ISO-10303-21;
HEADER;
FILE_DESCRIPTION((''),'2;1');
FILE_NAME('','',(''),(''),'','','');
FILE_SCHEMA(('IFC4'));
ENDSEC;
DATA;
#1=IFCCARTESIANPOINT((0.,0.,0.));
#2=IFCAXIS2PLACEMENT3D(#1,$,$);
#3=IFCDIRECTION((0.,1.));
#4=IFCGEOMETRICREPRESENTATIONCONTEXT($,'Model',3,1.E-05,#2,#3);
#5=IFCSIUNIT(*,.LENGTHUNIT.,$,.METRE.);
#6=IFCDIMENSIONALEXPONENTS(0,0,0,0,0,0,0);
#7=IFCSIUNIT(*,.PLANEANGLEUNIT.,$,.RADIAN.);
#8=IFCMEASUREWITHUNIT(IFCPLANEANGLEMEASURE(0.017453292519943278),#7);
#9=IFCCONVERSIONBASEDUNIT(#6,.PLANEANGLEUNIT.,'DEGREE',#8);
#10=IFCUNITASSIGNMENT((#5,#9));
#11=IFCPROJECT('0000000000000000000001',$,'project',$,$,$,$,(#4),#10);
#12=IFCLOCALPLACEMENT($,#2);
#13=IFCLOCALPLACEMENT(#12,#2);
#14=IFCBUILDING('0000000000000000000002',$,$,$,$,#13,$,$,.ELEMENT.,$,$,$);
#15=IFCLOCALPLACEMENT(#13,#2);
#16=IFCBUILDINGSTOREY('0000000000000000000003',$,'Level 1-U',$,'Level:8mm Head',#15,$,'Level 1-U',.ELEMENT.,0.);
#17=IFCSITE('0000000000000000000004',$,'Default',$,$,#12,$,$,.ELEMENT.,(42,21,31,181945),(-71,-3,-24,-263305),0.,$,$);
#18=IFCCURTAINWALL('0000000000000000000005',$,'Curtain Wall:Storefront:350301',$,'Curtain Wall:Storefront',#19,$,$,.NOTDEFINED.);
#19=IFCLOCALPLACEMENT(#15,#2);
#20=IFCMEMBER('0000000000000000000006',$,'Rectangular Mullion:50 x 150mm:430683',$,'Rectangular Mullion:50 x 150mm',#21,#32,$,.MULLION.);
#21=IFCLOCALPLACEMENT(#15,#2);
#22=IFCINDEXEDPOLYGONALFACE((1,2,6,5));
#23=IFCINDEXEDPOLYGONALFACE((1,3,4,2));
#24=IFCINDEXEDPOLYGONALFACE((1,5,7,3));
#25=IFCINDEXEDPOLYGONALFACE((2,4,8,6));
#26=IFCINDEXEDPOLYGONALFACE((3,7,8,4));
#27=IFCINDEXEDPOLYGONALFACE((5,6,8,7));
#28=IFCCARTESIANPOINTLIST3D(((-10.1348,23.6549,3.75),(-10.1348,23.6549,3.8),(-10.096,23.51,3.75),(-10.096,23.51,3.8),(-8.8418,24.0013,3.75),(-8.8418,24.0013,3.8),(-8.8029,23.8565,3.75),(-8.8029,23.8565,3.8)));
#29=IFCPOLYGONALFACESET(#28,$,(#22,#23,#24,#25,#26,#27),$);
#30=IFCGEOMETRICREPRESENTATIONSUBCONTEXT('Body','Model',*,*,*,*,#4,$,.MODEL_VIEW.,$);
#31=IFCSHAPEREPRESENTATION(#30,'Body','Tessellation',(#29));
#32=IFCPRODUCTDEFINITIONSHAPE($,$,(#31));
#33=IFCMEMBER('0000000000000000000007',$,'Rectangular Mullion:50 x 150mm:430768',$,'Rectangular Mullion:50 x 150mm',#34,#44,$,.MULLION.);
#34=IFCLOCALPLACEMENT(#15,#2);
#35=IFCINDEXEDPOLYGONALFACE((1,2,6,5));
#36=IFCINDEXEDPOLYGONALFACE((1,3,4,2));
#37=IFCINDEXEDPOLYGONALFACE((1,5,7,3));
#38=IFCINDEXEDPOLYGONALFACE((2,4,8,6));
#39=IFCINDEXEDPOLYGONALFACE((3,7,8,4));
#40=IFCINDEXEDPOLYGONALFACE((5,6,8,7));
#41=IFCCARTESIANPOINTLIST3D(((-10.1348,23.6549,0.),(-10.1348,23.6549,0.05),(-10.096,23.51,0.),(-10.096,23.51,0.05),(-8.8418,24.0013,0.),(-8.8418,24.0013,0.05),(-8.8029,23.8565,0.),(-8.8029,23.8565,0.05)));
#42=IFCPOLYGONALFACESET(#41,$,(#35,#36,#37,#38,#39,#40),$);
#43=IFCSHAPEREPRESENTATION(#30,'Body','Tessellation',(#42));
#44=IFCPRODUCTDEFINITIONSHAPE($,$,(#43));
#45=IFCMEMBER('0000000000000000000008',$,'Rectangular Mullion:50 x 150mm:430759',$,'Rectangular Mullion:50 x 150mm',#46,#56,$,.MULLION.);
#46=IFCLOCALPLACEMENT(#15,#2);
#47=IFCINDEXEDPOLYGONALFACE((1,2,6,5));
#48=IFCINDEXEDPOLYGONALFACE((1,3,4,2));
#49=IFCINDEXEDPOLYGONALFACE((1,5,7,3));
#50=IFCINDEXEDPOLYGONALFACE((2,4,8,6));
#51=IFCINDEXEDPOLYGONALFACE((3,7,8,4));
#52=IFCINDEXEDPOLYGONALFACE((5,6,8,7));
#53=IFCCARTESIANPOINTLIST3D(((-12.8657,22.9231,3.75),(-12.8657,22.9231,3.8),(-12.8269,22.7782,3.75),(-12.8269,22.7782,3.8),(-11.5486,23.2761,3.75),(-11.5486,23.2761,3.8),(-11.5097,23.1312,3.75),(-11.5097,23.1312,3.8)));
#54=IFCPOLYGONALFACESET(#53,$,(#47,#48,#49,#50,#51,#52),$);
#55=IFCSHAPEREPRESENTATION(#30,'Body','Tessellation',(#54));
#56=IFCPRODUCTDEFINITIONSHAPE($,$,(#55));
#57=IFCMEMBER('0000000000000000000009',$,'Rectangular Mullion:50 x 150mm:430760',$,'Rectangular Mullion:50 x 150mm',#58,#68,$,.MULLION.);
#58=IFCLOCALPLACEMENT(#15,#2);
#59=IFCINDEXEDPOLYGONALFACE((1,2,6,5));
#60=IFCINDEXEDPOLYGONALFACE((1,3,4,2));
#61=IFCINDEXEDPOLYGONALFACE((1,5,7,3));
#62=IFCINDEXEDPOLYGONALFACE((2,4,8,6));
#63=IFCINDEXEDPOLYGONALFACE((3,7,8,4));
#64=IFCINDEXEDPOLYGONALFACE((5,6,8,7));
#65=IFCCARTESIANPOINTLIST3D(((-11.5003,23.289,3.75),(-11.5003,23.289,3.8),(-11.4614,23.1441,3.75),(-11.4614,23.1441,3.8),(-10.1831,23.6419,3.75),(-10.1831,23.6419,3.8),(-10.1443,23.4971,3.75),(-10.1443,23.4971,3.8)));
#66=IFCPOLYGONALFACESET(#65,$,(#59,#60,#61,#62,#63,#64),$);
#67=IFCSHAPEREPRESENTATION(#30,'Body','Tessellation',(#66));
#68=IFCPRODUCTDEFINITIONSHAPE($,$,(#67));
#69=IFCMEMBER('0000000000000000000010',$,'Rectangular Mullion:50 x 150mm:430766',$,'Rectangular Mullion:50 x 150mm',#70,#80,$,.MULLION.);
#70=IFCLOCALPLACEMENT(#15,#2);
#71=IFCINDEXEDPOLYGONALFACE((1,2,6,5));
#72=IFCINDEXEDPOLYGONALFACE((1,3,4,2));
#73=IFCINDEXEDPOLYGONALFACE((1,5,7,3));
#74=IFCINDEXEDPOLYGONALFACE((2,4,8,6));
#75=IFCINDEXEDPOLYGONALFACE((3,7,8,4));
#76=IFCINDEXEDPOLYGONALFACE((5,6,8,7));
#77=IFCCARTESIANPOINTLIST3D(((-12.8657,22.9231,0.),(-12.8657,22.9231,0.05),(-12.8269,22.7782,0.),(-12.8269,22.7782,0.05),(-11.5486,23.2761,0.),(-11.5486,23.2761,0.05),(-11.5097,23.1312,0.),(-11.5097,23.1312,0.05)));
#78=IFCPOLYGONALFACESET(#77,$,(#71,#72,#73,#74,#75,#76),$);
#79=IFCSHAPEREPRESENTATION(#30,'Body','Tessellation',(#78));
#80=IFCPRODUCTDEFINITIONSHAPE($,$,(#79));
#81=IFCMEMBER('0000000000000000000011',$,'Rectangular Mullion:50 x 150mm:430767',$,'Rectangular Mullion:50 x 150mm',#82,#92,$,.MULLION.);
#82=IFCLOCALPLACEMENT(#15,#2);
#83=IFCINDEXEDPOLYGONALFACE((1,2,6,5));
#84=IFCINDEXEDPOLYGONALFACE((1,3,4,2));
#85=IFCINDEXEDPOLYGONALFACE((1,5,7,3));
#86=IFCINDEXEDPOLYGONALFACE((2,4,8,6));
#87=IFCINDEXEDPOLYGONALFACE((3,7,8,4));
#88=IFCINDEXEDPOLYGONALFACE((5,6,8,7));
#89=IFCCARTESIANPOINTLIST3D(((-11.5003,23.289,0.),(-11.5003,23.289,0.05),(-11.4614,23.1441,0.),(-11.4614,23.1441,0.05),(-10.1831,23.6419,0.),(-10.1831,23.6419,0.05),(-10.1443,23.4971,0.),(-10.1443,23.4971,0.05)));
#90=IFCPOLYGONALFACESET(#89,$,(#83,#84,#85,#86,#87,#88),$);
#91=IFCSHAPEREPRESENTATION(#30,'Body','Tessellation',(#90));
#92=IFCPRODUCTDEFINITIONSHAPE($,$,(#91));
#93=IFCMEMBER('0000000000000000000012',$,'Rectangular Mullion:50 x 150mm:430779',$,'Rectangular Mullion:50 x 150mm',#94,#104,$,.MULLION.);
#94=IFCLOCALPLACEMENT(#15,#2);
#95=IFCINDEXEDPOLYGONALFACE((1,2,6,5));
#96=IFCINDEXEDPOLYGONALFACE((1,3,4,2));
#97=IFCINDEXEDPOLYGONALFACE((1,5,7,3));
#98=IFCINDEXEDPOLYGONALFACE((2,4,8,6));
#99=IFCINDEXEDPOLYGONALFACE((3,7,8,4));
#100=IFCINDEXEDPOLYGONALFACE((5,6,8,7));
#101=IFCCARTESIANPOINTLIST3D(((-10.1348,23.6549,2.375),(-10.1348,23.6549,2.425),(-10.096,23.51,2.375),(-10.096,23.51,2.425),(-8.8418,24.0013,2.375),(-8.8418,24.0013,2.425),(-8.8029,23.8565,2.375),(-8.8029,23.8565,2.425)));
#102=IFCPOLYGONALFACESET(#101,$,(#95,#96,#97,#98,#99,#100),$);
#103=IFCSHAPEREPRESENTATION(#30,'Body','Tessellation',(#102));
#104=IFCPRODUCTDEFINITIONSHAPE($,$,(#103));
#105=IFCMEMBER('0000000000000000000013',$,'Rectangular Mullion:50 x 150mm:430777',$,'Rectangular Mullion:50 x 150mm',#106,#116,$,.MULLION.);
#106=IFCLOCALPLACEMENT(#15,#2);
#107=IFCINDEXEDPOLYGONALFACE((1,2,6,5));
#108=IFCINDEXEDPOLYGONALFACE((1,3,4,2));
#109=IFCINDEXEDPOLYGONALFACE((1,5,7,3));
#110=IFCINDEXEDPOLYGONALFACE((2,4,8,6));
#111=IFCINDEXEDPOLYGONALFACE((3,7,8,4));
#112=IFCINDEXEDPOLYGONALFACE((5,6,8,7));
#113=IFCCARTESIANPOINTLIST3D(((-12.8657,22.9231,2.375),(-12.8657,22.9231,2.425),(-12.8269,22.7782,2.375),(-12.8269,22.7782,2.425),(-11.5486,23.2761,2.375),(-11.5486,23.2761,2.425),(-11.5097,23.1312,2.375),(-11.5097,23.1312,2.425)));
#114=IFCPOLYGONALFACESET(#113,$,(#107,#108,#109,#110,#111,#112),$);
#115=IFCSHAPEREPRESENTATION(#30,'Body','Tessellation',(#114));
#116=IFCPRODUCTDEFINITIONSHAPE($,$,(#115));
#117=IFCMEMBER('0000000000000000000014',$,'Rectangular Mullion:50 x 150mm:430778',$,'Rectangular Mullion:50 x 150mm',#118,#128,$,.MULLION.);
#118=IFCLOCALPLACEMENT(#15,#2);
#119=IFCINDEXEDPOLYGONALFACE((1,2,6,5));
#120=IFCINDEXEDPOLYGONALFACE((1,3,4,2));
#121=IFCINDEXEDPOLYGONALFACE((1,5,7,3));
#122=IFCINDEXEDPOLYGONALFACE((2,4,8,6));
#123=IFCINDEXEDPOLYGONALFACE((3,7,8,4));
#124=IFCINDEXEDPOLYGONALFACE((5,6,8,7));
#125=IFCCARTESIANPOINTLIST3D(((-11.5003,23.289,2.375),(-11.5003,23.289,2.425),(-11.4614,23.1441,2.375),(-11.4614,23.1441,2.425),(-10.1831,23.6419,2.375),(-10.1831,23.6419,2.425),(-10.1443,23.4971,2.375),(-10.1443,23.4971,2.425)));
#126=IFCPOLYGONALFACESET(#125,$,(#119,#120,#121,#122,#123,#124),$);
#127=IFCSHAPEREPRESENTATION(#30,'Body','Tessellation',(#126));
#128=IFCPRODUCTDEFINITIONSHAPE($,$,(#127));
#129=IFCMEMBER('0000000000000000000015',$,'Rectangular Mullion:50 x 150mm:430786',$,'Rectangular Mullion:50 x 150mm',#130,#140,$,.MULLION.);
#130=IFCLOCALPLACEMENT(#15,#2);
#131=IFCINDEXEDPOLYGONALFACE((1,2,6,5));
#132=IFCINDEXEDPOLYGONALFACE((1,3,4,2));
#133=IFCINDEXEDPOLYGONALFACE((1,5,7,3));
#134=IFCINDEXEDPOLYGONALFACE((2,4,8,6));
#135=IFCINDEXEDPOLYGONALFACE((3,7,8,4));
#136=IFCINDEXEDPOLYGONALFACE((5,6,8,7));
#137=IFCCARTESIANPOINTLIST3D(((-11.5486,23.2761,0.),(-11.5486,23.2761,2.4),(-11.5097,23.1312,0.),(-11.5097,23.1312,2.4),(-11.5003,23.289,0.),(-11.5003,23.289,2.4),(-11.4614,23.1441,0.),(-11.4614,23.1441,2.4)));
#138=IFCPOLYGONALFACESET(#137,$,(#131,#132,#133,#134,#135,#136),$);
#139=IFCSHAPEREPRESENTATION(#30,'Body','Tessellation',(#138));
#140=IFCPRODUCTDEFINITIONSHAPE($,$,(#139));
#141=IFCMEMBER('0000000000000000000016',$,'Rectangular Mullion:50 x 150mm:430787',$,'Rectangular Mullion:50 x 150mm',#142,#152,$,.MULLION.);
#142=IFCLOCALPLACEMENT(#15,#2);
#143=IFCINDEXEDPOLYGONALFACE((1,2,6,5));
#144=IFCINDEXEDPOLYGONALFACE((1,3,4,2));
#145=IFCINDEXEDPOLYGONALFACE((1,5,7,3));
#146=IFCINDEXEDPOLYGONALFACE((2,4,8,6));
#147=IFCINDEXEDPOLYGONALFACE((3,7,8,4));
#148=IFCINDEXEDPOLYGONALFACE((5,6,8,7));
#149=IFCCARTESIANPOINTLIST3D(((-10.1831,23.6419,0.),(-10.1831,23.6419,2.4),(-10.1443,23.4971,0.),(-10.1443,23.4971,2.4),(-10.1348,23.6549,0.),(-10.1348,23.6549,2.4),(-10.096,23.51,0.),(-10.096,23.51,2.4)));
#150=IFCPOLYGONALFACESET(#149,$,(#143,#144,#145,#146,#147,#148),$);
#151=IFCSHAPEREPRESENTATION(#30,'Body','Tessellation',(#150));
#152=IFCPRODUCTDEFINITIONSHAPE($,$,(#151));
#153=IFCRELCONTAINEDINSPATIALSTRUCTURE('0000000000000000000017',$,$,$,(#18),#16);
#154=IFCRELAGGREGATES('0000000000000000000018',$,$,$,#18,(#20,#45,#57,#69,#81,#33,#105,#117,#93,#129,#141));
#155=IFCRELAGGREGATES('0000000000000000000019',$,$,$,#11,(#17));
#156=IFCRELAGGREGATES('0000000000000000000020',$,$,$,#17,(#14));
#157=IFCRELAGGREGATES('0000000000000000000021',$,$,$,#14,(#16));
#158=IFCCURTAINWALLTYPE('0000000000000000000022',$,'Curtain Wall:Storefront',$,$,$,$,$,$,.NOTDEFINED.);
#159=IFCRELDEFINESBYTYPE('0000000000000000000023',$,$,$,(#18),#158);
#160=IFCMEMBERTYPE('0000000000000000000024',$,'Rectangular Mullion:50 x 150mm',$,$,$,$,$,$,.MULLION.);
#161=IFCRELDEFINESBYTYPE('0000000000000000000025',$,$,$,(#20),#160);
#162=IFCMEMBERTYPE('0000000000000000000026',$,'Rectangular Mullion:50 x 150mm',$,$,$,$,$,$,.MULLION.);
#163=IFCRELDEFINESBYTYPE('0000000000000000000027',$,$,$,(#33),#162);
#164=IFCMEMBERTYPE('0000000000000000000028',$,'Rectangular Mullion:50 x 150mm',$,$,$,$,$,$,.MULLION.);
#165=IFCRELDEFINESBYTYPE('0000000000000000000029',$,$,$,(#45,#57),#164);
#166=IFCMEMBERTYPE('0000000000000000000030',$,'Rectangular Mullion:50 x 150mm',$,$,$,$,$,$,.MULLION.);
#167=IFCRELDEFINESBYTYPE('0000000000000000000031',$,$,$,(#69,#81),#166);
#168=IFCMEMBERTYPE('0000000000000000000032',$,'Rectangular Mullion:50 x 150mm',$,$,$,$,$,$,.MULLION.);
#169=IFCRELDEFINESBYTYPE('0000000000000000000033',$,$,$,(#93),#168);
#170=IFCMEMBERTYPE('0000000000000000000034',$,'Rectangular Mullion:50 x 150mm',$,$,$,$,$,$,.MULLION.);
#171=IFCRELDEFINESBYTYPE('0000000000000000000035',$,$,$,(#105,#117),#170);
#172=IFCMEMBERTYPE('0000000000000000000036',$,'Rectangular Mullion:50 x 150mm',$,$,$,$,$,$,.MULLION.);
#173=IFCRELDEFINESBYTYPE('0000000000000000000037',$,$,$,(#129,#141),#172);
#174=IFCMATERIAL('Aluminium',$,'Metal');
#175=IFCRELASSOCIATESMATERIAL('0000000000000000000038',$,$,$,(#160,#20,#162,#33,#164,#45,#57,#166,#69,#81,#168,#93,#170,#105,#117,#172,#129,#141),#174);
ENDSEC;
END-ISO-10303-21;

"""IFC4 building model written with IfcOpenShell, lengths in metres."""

from ifc_helpers import new_model, entity, si_unit, converted_unit, direction, frame, origin, place, context, subcontext, project, spatial, indexed_curve, outline, extrude, source, transform, mapped, material, type_object, type_shapes, element, aggregate, save


model = new_model("IFC4")

# Units and contexts
model_context = context("Model", 3, precision=1e-05, world=origin(), true_north=direction((0.0, 1.0)))
body_context = subcontext(model_context, "Body", "Model", "MODEL_VIEW")
ifc_project = project(units=[si_unit("LENGTHUNIT", "METRE"), converted_unit("PLANEANGLEUNIT", "DEGREE", entity("IfcPlaneAngleMeasure", 0.017453292519943278), si_unit("PLANEANGLEUNIT", "RADIAN"), dimensions=[0, 0, 0, 0, 0, 0, 0])], contexts=[model_context])

# Site, building, storey
site_placement = place(None, origin())
site = spatial("IfcSite", under=ifc_project, at=site_placement, Name="Default", CompositionType="ELEMENT", RefLatitude=(42, 21, 31, 181945), RefLongitude=(-71, -3, -24, -263305), RefElevation=0.0)
building_placement = place(site_placement, origin())
building = spatial("IfcBuilding", under=site, at=building_placement, CompositionType="ELEMENT")
storey_placement = place(building_placement, origin())
storey = spatial("IfcBuildingStorey", under=building, at=storey_placement, Name="Level 1-U", ObjectType="Level:8mm Head", LongName="Level 1-U", CompositionType="ELEMENT", Elevation=0.0)

# Curtain wall, members
curtain_wall_type = type_object("IfcCurtainWallType", Name="Curtain Wall:Storefront", PredefinedType="NOTDEFINED")
curtain_wall_placement = place(storey_placement, origin())
curtain_wall = element("IfcCurtainWall", 1, at=curtain_wall_placement, inside=storey, type_object=curtain_wall_type, Name="Curtain Wall:Storefront:350301", ObjectType="Curtain Wall:Storefront", PredefinedType="NOTDEFINED")
ifc_material_1 = material(Name="Aluminium", Category="Metal")
member_type_1 = type_object("IfcMemberType", Name="Rectangular Mullion:50 x 150mm", PredefinedType="MULLION", material=ifc_material_1)
shared_shape_1 = source(origin(), body_context, "Body", "SweptSolid", [
    extrude(outline(indexed_curve([(-0.025, -0.075), (0.025, -0.075), (0.025, 0.075), (-0.025, 0.075), (-0.025, -0.075)], self_intersect=False)), frame((-0.025, 0.0, -1.3386), z_axis=(0.0, 0.0, 1.0), x_axis=(-1.0, 0.0, 0.0)), (0.0, 0.0, 1.0), 1.3386),
])
type_shapes(member_type_1, [shared_shape_1])
member_1_placement = place(curtain_wall_placement, frame((-8.8224, 23.9289, 3.8), z_axis=(0.965926, 0.258819, 0.0), x_axis=(0.0, 0.0, 1.0)))
member_1 = element("IfcMember", 2, at=member_1_placement, type_object=member_type_1, material=ifc_material_1, Name="Rectangular Mullion:50 x 150mm:430683", ObjectType="Rectangular Mullion:50 x 150mm", PredefinedType="MULLION", context=body_context, shape_type="MappedRepresentation", body=[
    mapped(shared_shape_1, transform((0.0, 0.0, 0.0), scale=1.0)),
])
member_type_2 = type_object("IfcMemberType", Name="Rectangular Mullion:50 x 150mm", PredefinedType="MULLION", material=ifc_material_1)
shared_shape_2 = source(origin(), body_context, "Body", "SweptSolid", [
    extrude(outline(indexed_curve([(-0.025, -0.075), (0.025, -0.075), (0.025, 0.075), (-0.025, 0.075), (-0.025, -0.075)], self_intersect=False)), frame((-0.025, 0.0, -1.3386), z_axis=(0.0, 0.0, 1.0), x_axis=(-1.0, 0.0, 0.0)), (0.0, 0.0, 1.0), 1.3386),
])
type_shapes(member_type_2, [shared_shape_2])
member_2_placement = place(curtain_wall_placement, frame((-10.1154, 23.5824, 0.0), z_axis=(-0.965926, -0.258819, 0.0), x_axis=(0.0, 0.0, -1.0)))
member_2 = element("IfcMember", 3, at=member_2_placement, type_object=member_type_2, material=ifc_material_1, Name="Rectangular Mullion:50 x 150mm:430768", ObjectType="Rectangular Mullion:50 x 150mm", PredefinedType="MULLION", context=body_context, shape_type="MappedRepresentation", body=[
    mapped(shared_shape_2, transform((0.0, 0.0, 0.0), scale=1.0)),
])
member_type_3 = type_object("IfcMemberType", Name="Rectangular Mullion:50 x 150mm", PredefinedType="MULLION", material=ifc_material_1)
shared_shape_3 = source(origin(), body_context, "Body", "SweptSolid", [
    extrude(outline(indexed_curve([(-0.025, -0.075), (0.025, -0.075), (0.025, 0.075), (-0.025, 0.075), (-0.025, -0.075)], self_intersect=False)), frame((-0.025, 0.0, -1.3636), z_axis=(0.0, 0.0, 1.0), x_axis=(-1.0, 0.0, 0.0)), (0.0, 0.0, 1.0), 1.3636),
])
type_shapes(member_type_3, [shared_shape_3])
member_3_placement = place(curtain_wall_placement, frame((-11.5291, 23.2036, 3.8), z_axis=(0.965926, 0.258819, 0.0), x_axis=(0.0, 0.0, 1.0)))
member_3 = element("IfcMember", 4, at=member_3_placement, type_object=member_type_3, material=ifc_material_1, Name="Rectangular Mullion:50 x 150mm:430759", ObjectType="Rectangular Mullion:50 x 150mm", PredefinedType="MULLION", context=body_context, shape_type="MappedRepresentation", body=[
    mapped(shared_shape_3, transform((0.0, 0.0, 0.0), scale=1.0)),
])
member_4_placement = place(curtain_wall_placement, frame((-10.1637, 23.5695, 3.8), z_axis=(0.965926, 0.258819, 0.0), x_axis=(0.0, 0.0, 1.0)))
member_4 = element("IfcMember", 5, at=member_4_placement, type_object=member_type_3, material=ifc_material_1, Name="Rectangular Mullion:50 x 150mm:430760", ObjectType="Rectangular Mullion:50 x 150mm", PredefinedType="MULLION", context=body_context, shape_type="MappedRepresentation", body=[
    mapped(shared_shape_3, transform((0.0, 0.0, 0.0), scale=1.0)),
])
member_type_4 = type_object("IfcMemberType", Name="Rectangular Mullion:50 x 150mm", PredefinedType="MULLION", material=ifc_material_1)
shared_shape_4 = source(origin(), body_context, "Body", "SweptSolid", [
    extrude(outline(indexed_curve([(-0.025, -0.075), (0.025, -0.075), (0.025, 0.075), (-0.025, 0.075), (-0.025, -0.075)], self_intersect=False)), frame((-0.025, 0.0, -1.3636), z_axis=(0.0, 0.0, 1.0), x_axis=(-1.0, 0.0, 0.0)), (0.0, 0.0, 1.0), 1.3636),
])
type_shapes(member_type_4, [shared_shape_4])
member_5_placement = place(curtain_wall_placement, frame((-12.8463, 22.8507, 0.0), z_axis=(-0.965926, -0.258819, 0.0), x_axis=(0.0, 0.0, -1.0)))
member_5 = element("IfcMember", 6, at=member_5_placement, type_object=member_type_4, material=ifc_material_1, Name="Rectangular Mullion:50 x 150mm:430766", ObjectType="Rectangular Mullion:50 x 150mm", PredefinedType="MULLION", context=body_context, shape_type="MappedRepresentation", body=[
    mapped(shared_shape_4, transform((0.0, 0.0, 0.0), scale=1.0)),
])
member_6_placement = place(curtain_wall_placement, frame((-11.4809, 23.2166, 0.0), z_axis=(-0.965926, -0.258819, 0.0), x_axis=(0.0, 0.0, -1.0)))
member_6 = element("IfcMember", 7, at=member_6_placement, type_object=member_type_4, material=ifc_material_1, Name="Rectangular Mullion:50 x 150mm:430767", ObjectType="Rectangular Mullion:50 x 150mm", PredefinedType="MULLION", context=body_context, shape_type="MappedRepresentation", body=[
    mapped(shared_shape_4, transform((0.0, 0.0, 0.0), scale=1.0)),
])
member_type_5 = type_object("IfcMemberType", Name="Rectangular Mullion:50 x 150mm", PredefinedType="MULLION", material=ifc_material_1)
shared_shape_5 = source(origin(), body_context, "Body", "SweptSolid", [
    extrude(outline(indexed_curve([(-0.025, -0.075), (0.025, -0.075), (0.025, 0.075), (-0.025, 0.075), (-0.025, -0.075)], self_intersect=False)), frame((0.0, 0.0, -1.3386), z_axis=(0.0, 0.0, 1.0), x_axis=(-1.0, 0.0, 0.0)), (0.0, 0.0, 1.0), 1.3386),
])
type_shapes(member_type_5, [shared_shape_5])
member_7_placement = place(curtain_wall_placement, frame((-8.8224, 23.9289, 2.4), z_axis=(0.965926, 0.258819, 0.0), x_axis=(0.0, 0.0, 1.0)))
member_7 = element("IfcMember", 8, at=member_7_placement, type_object=member_type_5, material=ifc_material_1, Name="Rectangular Mullion:50 x 150mm:430779", ObjectType="Rectangular Mullion:50 x 150mm", PredefinedType="MULLION", context=body_context, shape_type="MappedRepresentation", body=[
    mapped(shared_shape_5, transform((0.0, 0.0, 0.0), scale=1.0)),
])
member_type_6 = type_object("IfcMemberType", Name="Rectangular Mullion:50 x 150mm", PredefinedType="MULLION", material=ifc_material_1)
shared_shape_6 = source(origin(), body_context, "Body", "SweptSolid", [
    extrude(outline(indexed_curve([(-0.025, -0.075), (0.025, -0.075), (0.025, 0.075), (-0.025, 0.075), (-0.025, -0.075)], self_intersect=False)), frame((0.0, 0.0, -1.3636), z_axis=(0.0, 0.0, 1.0), x_axis=(-1.0, 0.0, 0.0)), (0.0, 0.0, 1.0), 1.3636),
])
type_shapes(member_type_6, [shared_shape_6])
member_8_placement = place(curtain_wall_placement, frame((-11.5291, 23.2036, 2.4), z_axis=(0.965926, 0.258819, 0.0), x_axis=(0.0, 0.0, 1.0)))
member_8 = element("IfcMember", 9, at=member_8_placement, type_object=member_type_6, material=ifc_material_1, Name="Rectangular Mullion:50 x 150mm:430777", ObjectType="Rectangular Mullion:50 x 150mm", PredefinedType="MULLION", context=body_context, shape_type="MappedRepresentation", body=[
    mapped(shared_shape_6, transform((0.0, 0.0, 0.0), scale=1.0)),
])
member_9_placement = place(curtain_wall_placement, frame((-10.1637, 23.5695, 2.4), z_axis=(0.965926, 0.258819, 0.0), x_axis=(0.0, 0.0, 1.0)))
member_9 = element("IfcMember", 10, at=member_9_placement, type_object=member_type_6, material=ifc_material_1, Name="Rectangular Mullion:50 x 150mm:430778", ObjectType="Rectangular Mullion:50 x 150mm", PredefinedType="MULLION", context=body_context, shape_type="MappedRepresentation", body=[
    mapped(shared_shape_6, transform((0.0, 0.0, 0.0), scale=1.0)),
])
member_type_7 = type_object("IfcMemberType", Name="Rectangular Mullion:50 x 150mm", PredefinedType="MULLION", material=ifc_material_1)
shared_shape_7 = source(origin(), body_context, "Body", "SweptSolid", [
    extrude(outline(indexed_curve([(-0.025, -0.075), (0.025, -0.075), (0.025, 0.075), (-0.025, 0.075), (-0.025, -0.075)], self_intersect=False)), frame((0.0, 0.0, -2.4), z_axis=(0.0, 0.0, 1.0), x_axis=(-1.0, 0.0, 0.0)), (0.0, 0.0, 1.0), 2.4),
])
type_shapes(member_type_7, [shared_shape_7])
member_10_placement = place(curtain_wall_placement, frame((-11.505, 23.2101, 0.0), z_axis=(0.0, 0.0, -1.0), x_axis=(0.965926, 0.258819, 0.0)))
member_10 = element("IfcMember", 11, at=member_10_placement, type_object=member_type_7, material=ifc_material_1, Name="Rectangular Mullion:50 x 150mm:430786", ObjectType="Rectangular Mullion:50 x 150mm", PredefinedType="MULLION", context=body_context, shape_type="MappedRepresentation", body=[
    mapped(shared_shape_7, transform((0.0, 0.0, 0.0), scale=1.0)),
])
member_11_placement = place(curtain_wall_placement, frame((-10.1395, 23.576, 0.0), z_axis=(0.0, 0.0, -1.0), x_axis=(0.965926, 0.258819, 0.0)))
member_11 = element("IfcMember", 12, at=member_11_placement, type_object=member_type_7, material=ifc_material_1, Name="Rectangular Mullion:50 x 150mm:430787", ObjectType="Rectangular Mullion:50 x 150mm", PredefinedType="MULLION", context=body_context, shape_type="MappedRepresentation", body=[
    mapped(shared_shape_7, transform((0.0, 0.0, 0.0), scale=1.0)),
])
aggregate(curtain_wall, [member_1, member_3, member_4, member_5, member_6, member_2, member_8, member_9, member_7, member_10, member_11])

save(model, "model.ifc")
